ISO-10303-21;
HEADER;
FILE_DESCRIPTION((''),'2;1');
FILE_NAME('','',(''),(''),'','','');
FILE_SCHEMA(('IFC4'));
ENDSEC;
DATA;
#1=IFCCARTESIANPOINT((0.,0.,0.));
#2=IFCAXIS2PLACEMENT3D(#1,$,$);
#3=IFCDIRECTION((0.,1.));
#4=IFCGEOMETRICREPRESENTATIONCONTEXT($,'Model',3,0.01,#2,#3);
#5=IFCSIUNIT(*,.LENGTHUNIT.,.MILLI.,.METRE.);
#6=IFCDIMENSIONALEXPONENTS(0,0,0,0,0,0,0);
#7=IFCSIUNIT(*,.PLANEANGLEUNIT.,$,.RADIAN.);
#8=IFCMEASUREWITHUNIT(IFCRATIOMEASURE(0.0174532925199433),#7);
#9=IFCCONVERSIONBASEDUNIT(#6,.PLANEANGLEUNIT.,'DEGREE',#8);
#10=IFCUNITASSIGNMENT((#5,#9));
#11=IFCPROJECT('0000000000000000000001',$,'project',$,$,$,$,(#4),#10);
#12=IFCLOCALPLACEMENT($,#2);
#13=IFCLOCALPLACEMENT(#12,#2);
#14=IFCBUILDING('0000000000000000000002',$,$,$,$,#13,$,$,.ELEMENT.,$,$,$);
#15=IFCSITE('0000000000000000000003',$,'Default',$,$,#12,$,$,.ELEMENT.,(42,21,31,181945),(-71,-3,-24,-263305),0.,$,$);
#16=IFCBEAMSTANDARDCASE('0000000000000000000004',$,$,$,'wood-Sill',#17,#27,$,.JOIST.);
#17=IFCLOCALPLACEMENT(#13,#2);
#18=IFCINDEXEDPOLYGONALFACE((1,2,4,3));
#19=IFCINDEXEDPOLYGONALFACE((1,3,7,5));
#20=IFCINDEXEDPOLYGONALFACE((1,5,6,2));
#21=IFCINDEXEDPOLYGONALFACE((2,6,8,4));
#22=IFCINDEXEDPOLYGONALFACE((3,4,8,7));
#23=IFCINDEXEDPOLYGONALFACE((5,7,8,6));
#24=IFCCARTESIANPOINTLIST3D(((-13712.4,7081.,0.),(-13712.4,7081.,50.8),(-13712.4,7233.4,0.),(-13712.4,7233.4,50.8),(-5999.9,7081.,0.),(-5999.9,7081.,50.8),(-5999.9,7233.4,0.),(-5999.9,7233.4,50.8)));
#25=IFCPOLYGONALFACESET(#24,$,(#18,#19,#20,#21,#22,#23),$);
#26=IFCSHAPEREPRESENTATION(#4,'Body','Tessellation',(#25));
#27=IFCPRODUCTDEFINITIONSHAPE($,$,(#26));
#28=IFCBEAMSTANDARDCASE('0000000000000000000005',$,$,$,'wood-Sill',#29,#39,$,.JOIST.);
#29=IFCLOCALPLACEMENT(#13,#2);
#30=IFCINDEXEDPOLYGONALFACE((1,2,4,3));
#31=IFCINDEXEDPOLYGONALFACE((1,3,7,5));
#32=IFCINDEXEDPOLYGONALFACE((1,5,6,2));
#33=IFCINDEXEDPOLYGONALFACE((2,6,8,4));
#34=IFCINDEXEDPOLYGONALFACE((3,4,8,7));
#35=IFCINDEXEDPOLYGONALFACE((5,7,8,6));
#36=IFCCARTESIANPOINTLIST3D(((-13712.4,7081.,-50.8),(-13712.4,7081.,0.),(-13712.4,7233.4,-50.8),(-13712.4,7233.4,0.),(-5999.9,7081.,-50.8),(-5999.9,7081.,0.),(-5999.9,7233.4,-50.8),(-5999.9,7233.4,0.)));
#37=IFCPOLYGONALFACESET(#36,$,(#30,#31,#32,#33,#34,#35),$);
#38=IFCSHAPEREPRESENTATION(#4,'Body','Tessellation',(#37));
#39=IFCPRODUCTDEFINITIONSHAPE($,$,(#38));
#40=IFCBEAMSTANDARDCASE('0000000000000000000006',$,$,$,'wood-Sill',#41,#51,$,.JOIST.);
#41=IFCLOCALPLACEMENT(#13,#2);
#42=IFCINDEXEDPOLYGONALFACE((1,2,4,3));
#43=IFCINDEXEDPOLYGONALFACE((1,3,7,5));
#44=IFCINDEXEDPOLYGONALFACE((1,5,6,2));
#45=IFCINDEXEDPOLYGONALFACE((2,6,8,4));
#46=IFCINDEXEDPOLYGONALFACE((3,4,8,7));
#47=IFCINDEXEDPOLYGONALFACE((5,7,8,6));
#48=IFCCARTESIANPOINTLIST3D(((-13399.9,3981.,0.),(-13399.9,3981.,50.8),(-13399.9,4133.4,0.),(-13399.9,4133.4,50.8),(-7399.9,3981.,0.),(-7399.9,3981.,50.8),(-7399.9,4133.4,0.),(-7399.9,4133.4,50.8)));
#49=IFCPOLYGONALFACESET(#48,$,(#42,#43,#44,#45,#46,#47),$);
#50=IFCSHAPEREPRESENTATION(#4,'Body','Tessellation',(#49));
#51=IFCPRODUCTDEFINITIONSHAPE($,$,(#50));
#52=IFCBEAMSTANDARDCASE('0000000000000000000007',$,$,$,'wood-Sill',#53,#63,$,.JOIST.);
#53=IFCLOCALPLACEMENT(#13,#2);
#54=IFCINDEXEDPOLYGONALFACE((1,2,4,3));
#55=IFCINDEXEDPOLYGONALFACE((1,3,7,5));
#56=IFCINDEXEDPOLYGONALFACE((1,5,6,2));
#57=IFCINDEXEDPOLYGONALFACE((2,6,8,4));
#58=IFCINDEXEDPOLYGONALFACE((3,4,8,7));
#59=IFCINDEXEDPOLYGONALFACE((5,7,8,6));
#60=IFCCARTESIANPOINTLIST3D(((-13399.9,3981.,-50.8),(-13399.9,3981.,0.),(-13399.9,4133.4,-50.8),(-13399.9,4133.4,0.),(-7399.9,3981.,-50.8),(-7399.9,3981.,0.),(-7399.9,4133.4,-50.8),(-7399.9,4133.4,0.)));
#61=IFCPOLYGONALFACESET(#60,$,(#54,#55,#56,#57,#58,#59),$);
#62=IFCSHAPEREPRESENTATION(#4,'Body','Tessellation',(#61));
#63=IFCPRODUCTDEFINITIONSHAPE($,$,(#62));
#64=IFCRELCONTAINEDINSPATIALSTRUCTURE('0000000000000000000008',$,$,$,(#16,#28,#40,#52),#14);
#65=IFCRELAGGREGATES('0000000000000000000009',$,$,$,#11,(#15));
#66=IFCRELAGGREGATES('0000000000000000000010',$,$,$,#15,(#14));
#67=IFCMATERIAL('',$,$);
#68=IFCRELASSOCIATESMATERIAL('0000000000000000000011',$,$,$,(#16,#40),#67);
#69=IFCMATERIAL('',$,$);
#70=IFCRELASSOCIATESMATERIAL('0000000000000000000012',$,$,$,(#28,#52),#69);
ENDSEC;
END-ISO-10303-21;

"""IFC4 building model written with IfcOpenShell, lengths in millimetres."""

from ifc_helpers import new_model, entity, si_unit, converted_unit, direction, frame, origin, place, context, project, spatial, rectangle, extrude, material, element, save


model = new_model("IFC4")

# Units and contexts
model_context = context("Model", 3, precision=0.01, world=origin(), true_north=direction((0.0, 1.0)))
ifc_project = project(units=[si_unit("LENGTHUNIT", "METRE", prefix="MILLI"), converted_unit("PLANEANGLEUNIT", "DEGREE", entity("IfcRatioMeasure", 0.0174532925199433), si_unit("PLANEANGLEUNIT", "RADIAN"), dimensions=[0, 0, 0, 0, 0, 0, 0])], contexts=[model_context])

# Site, building
site_placement = place(None, origin())
site = spatial("IfcSite", under=ifc_project, at=site_placement, Name="Default", CompositionType="ELEMENT", RefLatitude=(42, 21, 31, 181945), RefLongitude=(-71, -3, -24, -263305), RefElevation=0.0)
building_placement = place(site_placement, origin())
building = spatial("IfcBuilding", under=site, at=building_placement, CompositionType="ELEMENT")

# Shared definitions
placement_1 = place(building_placement, origin())
placement_2 = place(placement_1, frame((-13712.4, 7157.2, 0.0)))
placement_3 = place(placement_1, frame((-10399.9, 7057.2, 0.0), z_axis=(0.0, 0.0, 1.0), x_axis=(0.0, -1.0, 0.0)))

# Beams
ifc_material_1 = material(Name="")
beam_1_placement = place(placement_2, frame((3856.2, 0.0, 0.0)))
element("IfcBeamStandardCase", 1, at=beam_1_placement, inside=building, material=ifc_material_1, ObjectType="wood-Sill", PredefinedType="JOIST", context=model_context, shape_type="SweptSolid", body=[
    extrude(rectangle(XDim=7712.5, YDim=152.4), origin(), (0.0, 0.0, 1.0), 50.8),
])
ifc_material_2 = material(Name="")
beam_2_placement = place(placement_2, frame((3856.2, 0.0, -50.8)))
element("IfcBeamStandardCase", 2, at=beam_2_placement, inside=building, material=ifc_material_2, ObjectType="wood-Sill", PredefinedType="JOIST", context=model_context, shape_type="SweptSolid", body=[
    extrude(rectangle(XDim=7712.5, YDim=152.4), origin(), (0.0, 0.0, 1.0), 50.8),
])
beam_3_placement = place(placement_3, frame((3000.0, 0.0, 0.0), z_axis=(0.0, 0.0, 1.0), x_axis=(0.0, -1.0, 0.0)))
element("IfcBeamStandardCase", 3, at=beam_3_placement, inside=building, material=ifc_material_1, ObjectType="wood-Sill", PredefinedType="JOIST", context=model_context, shape_type="SweptSolid", body=[
    extrude(rectangle(XDim=6000.0, YDim=152.4), origin(), (0.0, 0.0, 1.0), 50.8),
])
beam_4_placement = place(placement_3, frame((3000.0, 0.0, -50.8), z_axis=(0.0, 0.0, 1.0), x_axis=(0.0, -1.0, 0.0)))
element("IfcBeamStandardCase", 4, at=beam_4_placement, inside=building, material=ifc_material_2, ObjectType="wood-Sill", PredefinedType="JOIST", context=model_context, shape_type="SweptSolid", body=[
    extrude(rectangle(XDim=6000.0, YDim=152.4), origin(), (0.0, 0.0, 1.0), 50.8),
])

save(model, "model.ifc")
